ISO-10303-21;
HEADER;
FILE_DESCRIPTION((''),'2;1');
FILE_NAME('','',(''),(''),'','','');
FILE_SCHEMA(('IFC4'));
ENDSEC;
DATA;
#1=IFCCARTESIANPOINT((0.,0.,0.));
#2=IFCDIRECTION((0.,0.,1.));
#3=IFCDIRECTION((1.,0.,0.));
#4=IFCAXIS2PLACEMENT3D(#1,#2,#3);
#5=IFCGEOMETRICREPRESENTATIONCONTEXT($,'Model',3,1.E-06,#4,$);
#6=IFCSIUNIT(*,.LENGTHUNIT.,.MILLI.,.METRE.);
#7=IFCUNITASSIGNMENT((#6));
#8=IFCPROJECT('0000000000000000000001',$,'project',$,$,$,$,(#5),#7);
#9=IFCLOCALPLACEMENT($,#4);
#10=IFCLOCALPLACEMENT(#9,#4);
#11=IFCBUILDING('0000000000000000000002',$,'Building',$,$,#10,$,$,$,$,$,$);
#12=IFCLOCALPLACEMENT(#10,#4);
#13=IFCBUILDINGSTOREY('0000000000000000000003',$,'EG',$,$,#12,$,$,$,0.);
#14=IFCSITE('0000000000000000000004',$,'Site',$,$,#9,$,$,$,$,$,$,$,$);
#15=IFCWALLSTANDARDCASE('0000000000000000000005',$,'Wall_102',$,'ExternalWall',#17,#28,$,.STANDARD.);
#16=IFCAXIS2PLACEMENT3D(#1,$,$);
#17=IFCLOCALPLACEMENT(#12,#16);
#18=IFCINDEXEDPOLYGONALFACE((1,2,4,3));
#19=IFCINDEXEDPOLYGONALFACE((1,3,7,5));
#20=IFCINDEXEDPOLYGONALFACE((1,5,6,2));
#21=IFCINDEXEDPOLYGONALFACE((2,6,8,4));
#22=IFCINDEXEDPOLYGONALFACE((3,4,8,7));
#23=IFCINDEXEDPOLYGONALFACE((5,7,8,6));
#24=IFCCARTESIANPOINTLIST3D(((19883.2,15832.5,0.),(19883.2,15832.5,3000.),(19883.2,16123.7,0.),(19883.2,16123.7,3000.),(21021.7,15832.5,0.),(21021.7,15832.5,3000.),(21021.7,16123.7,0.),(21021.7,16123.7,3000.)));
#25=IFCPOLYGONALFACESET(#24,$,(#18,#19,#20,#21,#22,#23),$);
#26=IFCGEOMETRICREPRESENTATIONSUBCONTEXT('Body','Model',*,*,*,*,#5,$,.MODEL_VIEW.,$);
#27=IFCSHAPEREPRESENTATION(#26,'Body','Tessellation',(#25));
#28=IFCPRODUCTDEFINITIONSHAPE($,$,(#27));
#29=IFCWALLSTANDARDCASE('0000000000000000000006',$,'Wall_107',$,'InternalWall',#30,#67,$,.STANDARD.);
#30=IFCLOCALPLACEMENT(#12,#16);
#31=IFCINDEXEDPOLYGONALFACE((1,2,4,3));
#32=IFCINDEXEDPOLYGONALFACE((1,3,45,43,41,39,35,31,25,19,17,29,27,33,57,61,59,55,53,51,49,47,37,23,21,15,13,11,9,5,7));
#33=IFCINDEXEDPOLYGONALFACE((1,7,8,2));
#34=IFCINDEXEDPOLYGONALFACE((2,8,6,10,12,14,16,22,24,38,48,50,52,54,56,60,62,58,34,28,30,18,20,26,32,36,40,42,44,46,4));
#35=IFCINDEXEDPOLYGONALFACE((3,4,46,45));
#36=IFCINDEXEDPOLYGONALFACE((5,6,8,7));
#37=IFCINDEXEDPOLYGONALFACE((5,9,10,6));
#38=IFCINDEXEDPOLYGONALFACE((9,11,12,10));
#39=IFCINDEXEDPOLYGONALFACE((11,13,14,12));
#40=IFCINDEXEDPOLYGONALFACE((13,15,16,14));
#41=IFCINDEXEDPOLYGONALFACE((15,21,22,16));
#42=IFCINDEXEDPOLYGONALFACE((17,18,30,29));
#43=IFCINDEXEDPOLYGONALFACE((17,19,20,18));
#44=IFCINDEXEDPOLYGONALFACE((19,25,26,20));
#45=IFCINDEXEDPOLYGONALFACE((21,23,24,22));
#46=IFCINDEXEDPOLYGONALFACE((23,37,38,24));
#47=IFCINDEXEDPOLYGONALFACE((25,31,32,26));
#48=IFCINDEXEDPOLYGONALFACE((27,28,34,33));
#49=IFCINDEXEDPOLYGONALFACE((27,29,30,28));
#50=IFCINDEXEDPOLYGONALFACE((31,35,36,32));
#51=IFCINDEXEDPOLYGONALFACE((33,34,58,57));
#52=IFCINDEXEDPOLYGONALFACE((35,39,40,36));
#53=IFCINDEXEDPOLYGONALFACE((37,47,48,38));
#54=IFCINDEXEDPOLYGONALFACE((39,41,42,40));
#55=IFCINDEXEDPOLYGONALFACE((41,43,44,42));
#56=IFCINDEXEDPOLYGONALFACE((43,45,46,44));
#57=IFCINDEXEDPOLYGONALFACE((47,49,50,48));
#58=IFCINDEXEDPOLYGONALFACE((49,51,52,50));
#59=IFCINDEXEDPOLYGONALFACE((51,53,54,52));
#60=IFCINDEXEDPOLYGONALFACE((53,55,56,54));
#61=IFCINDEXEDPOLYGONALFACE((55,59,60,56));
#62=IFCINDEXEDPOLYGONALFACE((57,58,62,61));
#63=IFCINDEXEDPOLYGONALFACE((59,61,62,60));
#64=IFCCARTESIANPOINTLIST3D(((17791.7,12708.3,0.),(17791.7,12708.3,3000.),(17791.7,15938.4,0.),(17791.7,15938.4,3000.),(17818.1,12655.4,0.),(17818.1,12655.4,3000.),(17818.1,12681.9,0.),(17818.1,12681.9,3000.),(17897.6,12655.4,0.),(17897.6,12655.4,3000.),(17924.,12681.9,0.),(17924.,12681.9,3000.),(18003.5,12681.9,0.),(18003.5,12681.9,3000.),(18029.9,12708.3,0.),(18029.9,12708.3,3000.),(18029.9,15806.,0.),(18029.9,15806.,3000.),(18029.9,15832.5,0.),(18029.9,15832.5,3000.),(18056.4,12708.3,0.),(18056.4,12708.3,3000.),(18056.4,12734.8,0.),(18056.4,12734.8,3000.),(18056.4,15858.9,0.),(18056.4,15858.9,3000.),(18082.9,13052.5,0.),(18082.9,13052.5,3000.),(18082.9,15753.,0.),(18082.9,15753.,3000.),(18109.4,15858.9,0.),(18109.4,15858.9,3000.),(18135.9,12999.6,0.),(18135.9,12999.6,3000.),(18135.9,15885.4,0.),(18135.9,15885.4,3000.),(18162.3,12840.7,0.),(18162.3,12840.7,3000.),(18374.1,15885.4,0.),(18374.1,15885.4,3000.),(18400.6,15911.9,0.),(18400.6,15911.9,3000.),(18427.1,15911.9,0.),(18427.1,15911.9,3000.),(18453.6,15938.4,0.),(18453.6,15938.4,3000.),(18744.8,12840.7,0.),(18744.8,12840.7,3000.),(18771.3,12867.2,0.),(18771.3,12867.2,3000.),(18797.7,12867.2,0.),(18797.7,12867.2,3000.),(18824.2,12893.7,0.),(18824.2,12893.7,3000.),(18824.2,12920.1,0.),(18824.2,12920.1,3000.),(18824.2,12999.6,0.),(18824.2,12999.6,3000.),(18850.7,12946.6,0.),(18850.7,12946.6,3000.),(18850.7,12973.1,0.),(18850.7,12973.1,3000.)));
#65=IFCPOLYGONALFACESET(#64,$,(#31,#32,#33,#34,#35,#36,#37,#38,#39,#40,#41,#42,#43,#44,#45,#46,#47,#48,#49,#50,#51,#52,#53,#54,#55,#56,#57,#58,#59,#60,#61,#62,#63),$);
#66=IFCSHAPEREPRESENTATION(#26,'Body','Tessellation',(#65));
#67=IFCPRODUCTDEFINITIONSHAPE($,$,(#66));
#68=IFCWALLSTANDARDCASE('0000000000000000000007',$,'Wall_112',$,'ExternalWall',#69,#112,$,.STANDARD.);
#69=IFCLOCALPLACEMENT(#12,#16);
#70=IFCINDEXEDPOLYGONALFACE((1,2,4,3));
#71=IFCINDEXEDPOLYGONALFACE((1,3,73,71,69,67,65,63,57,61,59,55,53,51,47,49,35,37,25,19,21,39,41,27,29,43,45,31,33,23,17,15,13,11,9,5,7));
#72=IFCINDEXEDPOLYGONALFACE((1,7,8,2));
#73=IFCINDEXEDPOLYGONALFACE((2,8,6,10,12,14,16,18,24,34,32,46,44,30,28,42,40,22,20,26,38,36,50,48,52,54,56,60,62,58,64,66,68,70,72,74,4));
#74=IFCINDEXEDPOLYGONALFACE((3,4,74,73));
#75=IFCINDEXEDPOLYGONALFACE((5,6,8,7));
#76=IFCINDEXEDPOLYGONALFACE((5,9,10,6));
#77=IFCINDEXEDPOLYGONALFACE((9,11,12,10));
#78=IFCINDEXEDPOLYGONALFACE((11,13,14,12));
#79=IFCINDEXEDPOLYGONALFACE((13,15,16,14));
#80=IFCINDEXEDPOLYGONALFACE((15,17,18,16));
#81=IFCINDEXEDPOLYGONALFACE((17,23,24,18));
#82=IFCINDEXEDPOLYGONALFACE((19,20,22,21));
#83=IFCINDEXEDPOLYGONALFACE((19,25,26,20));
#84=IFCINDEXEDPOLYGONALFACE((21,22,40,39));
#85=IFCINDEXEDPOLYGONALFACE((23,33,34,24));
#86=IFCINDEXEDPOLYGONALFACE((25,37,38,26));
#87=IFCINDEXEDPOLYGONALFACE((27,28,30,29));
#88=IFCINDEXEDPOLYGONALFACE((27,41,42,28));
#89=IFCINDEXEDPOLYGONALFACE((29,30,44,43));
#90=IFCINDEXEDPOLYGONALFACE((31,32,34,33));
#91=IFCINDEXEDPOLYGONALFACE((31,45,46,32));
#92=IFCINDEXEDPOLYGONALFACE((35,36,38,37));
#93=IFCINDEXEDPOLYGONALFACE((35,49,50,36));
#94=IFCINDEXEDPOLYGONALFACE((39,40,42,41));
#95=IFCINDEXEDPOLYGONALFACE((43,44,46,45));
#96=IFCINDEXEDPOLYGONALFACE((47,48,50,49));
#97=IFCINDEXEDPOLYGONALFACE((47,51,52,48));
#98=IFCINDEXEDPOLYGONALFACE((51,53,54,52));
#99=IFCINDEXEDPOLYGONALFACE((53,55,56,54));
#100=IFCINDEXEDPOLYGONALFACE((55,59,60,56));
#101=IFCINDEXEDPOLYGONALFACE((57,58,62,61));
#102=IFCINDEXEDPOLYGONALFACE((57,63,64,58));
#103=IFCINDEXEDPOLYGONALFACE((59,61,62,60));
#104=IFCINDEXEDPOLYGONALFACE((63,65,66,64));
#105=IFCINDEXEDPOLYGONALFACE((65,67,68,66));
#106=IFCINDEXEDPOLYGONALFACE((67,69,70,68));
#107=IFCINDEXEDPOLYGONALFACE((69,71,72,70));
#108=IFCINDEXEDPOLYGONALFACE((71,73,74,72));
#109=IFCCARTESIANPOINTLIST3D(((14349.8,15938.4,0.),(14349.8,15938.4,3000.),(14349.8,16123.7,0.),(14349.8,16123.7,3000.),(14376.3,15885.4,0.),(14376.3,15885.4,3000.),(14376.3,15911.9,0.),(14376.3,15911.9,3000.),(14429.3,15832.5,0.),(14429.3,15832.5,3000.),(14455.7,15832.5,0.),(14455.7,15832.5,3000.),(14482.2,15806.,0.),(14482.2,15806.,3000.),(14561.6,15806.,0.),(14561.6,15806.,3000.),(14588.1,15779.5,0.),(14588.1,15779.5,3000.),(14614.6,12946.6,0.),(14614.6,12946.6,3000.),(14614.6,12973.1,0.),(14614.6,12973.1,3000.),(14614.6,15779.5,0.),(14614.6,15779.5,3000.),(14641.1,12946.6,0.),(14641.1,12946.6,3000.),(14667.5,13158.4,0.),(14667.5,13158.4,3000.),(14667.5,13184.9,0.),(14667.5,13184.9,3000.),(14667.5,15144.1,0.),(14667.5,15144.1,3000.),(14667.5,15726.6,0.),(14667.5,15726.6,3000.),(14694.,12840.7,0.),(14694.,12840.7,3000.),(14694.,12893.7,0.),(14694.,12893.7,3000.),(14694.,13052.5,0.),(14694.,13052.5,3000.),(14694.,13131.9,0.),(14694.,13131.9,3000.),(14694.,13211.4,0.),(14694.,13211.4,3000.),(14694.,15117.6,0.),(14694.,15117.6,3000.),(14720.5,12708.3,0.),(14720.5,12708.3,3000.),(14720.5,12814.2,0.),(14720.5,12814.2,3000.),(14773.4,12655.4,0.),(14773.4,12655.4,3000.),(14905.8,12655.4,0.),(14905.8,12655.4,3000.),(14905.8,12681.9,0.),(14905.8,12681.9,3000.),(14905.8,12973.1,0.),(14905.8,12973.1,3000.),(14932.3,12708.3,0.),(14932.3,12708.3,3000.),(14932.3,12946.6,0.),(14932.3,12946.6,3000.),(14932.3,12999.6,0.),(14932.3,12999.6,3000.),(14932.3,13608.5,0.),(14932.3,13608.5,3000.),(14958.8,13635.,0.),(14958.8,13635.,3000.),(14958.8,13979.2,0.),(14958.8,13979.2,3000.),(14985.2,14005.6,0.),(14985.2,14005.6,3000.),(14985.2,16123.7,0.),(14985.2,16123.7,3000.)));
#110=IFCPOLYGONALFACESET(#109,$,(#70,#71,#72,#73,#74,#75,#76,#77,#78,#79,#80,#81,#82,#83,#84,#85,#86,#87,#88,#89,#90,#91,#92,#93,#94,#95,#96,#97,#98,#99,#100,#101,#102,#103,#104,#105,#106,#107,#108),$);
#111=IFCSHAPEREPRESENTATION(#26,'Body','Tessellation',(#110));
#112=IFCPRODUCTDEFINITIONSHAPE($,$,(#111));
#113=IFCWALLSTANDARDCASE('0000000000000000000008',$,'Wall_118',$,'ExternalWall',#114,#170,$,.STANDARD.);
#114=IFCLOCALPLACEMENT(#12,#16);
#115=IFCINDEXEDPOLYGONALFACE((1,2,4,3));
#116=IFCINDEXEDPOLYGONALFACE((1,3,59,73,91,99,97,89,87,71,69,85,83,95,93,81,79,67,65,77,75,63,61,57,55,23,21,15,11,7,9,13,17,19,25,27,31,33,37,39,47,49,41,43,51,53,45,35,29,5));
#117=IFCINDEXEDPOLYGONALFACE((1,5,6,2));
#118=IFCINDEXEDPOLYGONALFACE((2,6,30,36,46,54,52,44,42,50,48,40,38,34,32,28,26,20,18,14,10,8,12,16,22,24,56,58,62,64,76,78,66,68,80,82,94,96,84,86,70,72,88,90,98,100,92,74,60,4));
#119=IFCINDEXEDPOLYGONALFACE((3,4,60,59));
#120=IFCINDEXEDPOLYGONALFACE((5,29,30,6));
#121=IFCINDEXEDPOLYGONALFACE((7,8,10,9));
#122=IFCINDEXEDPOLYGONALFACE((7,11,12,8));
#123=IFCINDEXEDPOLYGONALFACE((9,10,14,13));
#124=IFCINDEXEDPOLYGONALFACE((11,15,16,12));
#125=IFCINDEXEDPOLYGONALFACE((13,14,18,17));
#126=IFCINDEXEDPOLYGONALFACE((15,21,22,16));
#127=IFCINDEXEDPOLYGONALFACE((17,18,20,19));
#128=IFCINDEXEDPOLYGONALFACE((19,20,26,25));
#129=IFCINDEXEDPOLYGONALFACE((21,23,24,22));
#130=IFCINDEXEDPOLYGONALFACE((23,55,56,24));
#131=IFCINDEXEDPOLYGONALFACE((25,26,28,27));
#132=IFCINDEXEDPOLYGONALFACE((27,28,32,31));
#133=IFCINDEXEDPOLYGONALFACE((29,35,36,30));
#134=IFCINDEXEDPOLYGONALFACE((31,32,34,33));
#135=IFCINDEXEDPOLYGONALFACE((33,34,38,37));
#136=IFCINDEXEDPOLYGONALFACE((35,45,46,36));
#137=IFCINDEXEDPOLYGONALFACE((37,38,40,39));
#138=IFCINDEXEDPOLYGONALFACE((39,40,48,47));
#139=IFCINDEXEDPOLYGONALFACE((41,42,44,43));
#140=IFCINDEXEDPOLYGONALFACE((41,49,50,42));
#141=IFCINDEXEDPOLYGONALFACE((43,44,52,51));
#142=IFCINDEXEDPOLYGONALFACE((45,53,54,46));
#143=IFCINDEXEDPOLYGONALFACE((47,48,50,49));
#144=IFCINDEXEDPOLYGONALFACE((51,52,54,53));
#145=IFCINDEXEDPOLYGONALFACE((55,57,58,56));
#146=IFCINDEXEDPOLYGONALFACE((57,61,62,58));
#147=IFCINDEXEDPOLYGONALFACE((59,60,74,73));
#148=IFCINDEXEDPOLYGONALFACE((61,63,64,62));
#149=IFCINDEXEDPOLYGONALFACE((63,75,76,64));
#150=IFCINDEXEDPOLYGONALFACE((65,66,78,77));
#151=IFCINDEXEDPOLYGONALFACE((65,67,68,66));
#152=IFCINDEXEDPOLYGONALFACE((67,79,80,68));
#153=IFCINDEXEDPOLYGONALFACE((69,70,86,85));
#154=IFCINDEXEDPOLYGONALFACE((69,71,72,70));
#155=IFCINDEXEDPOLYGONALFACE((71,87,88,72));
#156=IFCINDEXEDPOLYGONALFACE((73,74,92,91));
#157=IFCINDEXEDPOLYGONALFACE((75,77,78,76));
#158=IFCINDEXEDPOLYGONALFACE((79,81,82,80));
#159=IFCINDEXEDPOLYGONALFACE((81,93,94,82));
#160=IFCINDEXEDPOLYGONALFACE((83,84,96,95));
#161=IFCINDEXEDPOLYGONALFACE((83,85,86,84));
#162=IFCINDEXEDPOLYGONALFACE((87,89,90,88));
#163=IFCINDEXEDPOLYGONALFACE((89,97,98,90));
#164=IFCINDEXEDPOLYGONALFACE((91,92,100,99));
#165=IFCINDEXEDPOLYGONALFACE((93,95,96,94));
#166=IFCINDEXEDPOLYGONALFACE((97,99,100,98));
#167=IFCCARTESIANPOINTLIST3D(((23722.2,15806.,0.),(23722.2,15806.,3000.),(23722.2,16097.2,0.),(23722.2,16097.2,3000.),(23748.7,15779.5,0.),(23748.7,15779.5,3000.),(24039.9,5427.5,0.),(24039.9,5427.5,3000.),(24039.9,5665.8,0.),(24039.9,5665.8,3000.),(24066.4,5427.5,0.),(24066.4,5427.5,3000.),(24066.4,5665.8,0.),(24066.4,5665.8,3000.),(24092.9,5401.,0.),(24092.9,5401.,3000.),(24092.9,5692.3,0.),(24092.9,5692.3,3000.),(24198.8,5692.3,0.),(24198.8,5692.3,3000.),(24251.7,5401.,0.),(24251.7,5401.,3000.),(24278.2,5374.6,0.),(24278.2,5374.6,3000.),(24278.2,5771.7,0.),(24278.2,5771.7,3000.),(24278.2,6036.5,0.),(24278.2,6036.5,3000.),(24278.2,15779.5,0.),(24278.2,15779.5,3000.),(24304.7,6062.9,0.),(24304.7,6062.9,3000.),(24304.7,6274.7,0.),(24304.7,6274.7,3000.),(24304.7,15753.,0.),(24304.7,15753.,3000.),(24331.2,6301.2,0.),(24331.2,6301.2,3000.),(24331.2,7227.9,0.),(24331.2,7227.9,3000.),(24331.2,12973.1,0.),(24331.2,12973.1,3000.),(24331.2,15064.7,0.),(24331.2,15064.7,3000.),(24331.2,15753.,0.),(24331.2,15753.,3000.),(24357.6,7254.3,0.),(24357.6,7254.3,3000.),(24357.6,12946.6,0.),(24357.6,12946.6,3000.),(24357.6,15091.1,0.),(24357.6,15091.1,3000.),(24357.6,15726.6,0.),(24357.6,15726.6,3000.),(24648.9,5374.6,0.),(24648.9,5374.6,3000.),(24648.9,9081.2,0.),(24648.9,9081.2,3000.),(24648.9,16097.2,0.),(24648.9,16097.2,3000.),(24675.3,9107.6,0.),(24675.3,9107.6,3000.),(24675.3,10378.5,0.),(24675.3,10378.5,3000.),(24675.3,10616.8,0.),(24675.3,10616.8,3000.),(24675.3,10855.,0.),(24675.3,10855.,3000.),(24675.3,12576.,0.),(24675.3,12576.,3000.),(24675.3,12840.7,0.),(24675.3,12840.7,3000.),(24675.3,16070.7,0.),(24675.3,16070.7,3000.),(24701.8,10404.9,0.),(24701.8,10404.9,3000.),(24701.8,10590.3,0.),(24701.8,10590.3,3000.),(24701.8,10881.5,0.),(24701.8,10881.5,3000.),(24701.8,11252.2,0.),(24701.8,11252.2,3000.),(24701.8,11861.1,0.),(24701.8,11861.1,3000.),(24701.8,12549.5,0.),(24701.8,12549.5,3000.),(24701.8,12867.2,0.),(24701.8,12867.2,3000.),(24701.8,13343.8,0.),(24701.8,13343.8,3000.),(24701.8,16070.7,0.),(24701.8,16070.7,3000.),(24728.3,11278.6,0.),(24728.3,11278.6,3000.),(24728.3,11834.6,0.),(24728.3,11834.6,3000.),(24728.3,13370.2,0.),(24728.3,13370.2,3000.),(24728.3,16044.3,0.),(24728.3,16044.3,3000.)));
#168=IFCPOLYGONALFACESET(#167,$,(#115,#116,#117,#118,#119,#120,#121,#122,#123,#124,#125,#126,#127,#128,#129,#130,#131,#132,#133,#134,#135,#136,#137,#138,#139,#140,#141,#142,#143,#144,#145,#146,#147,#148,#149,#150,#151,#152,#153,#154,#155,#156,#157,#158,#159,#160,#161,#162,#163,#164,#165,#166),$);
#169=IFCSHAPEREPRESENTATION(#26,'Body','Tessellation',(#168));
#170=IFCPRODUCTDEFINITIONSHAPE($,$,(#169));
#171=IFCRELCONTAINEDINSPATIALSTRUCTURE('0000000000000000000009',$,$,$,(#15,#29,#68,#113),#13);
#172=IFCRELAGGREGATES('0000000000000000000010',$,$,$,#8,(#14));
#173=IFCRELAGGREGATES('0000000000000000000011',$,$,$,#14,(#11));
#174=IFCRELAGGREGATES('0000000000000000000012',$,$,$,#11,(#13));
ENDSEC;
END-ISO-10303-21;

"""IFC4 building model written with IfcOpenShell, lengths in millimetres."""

from ifc_helpers import new_model, si_unit, frame, origin_with_axes, place, context, subcontext, project, spatial, polyline, outline, extrude, element, save


model = new_model("IFC4")

# Units and contexts
model_context = context("Model", 3, precision=1e-06, world=origin_with_axes())
body_context = subcontext(model_context, "Body", "Model", "MODEL_VIEW")
ifc_project = project(units=[si_unit("LENGTHUNIT", "METRE", prefix="MILLI")], contexts=[model_context])

# Site, building, storey
site_placement = place(None, origin_with_axes())
site = spatial("IfcSite", under=ifc_project, at=site_placement, Name="Site")
building_placement = place(site_placement, origin_with_axes())
building = spatial("IfcBuilding", under=site, at=building_placement, Name="Building")
storey_placement = place(building_placement, origin_with_axes())
storey = spatial("IfcBuildingStorey", under=building, at=storey_placement, Name="EG", Elevation=0.0)

# Walls
for number, where, z_axis, x_axis, name in (
    (1, (0.0, 0.0, 0.0), (0.0, 0.0, 1.0), (1.0, 0.0, 0.0), "Wall_102"),
):
    element("IfcWallStandardCase", number, at=place(storey_placement, frame(where, z_axis=z_axis, x_axis=x_axis)), inside=storey, Name=name, ObjectType="ExternalWall", PredefinedType="STANDARD", context=body_context, shape_type="SweptSolid", body=[
        extrude(outline(polyline([(19883.2, 15832.5, 0.0), (19883.2, 16123.7, 0.0), (21021.7, 16123.7, 0.0), (21021.7, 15832.5, 0.0), (19883.2, 15832.5, 0.0)])), origin_with_axes(), (0.0, 0.0, 1.0), 3000.0),
    ])
for number, where, z_axis, x_axis, name in (
    (2, (0.0, 0.0, 0.0), (0.0, 0.0, 1.0), (1.0, 0.0, 0.0), "Wall_107"),
):
    element("IfcWallStandardCase", number, at=place(storey_placement, frame(where, z_axis=z_axis, x_axis=x_axis)), inside=storey, Name=name, ObjectType="InternalWall", PredefinedType="STANDARD", context=body_context, shape_type="SweptSolid", body=[
        extrude(outline(polyline([(17818.1, 12655.4, 0.0), (17818.1, 12681.9, 0.0), (17791.7, 12708.3, 0.0), (17791.7, 15938.4, 0.0), (18453.6, 15938.4, 0.0), (18427.1, 15911.9, 0.0), (18400.6, 15911.9, 0.0), (18374.1, 15885.4, 0.0), (18135.9, 15885.4, 0.0), (18109.4, 15858.9, 0.0), (18056.4, 15858.9, 0.0), (18029.9, 15832.5, 0.0), (18029.9, 15806.0, 0.0), (18082.9, 15753.0, 0.0), (18082.9, 13052.5, 0.0), (18135.9, 12999.6, 0.0), (18824.2, 12999.6, 0.0), (18850.7, 12973.1, 0.0), (18850.7, 12946.6, 0.0), (18824.2, 12920.1, 0.0), (18824.2, 12893.7, 0.0), (18797.7, 12867.2, 0.0), (18771.3, 12867.2, 0.0), (18744.8, 12840.7, 0.0), (18162.3, 12840.7, 0.0), (18056.4, 12734.8, 0.0), (18056.4, 12708.3, 0.0), (18029.9, 12708.3, 0.0), (18003.5, 12681.9, 0.0), (17924.0, 12681.9, 0.0), (17897.6, 12655.4, 0.0), (17818.1, 12655.4, 0.0)])), origin_with_axes(), (0.0, 0.0, 1.0), 3000.0),
    ])
for number, where, z_axis, x_axis, name in (
    (3, (0.0, 0.0, 0.0), (0.0, 0.0, 1.0), (1.0, 0.0, 0.0), "Wall_112"),
):
    element("IfcWallStandardCase", number, at=place(storey_placement, frame(where, z_axis=z_axis, x_axis=x_axis)), inside=storey, Name=name, ObjectType="ExternalWall", PredefinedType="STANDARD", context=body_context, shape_type="SweptSolid", body=[
        extrude(outline(polyline([(14773.4, 12655.4, 0.0), (14720.5, 12708.3, 0.0), (14720.5, 12814.2, 0.0), (14694.0, 12840.7, 0.0), (14694.0, 12893.7, 0.0), (14641.1, 12946.6, 0.0), (14614.6, 12946.6, 0.0), (14614.6, 12973.1, 0.0), (14694.0, 13052.5, 0.0), (14694.0, 13131.9, 0.0), (14667.5, 13158.4, 0.0), (14667.5, 13184.9, 0.0), (14694.0, 13211.4, 0.0), (14694.0, 15117.6, 0.0), (14667.5, 15144.1, 0.0), (14667.5, 15726.6, 0.0), (14614.6, 15779.5, 0.0), (14588.1, 15779.5, 0.0), (14561.6, 15806.0, 0.0), (14482.2, 15806.0, 0.0), (14455.7, 15832.5, 0.0), (14429.3, 15832.5, 0.0), (14376.3, 15885.4, 0.0), (14376.3, 15911.9, 0.0), (14349.8, 15938.4, 0.0), (14349.8, 16123.7, 0.0), (14985.2, 16123.7, 0.0), (14985.2, 14005.6, 0.0), (14958.8, 13979.2, 0.0), (14958.8, 13635.0, 0.0), (14932.3, 13608.5, 0.0), (14932.3, 12999.6, 0.0), (14905.8, 12973.1, 0.0), (14932.3, 12946.6, 0.0), (14932.3, 12708.3, 0.0), (14905.8, 12681.9, 0.0), (14905.8, 12655.4, 0.0), (14773.4, 12655.4, 0.0)])), origin_with_axes(), (0.0, 0.0, 1.0), 3000.0),
    ])
wall_1_placement = place(storey_placement, origin_with_axes())
element("IfcWallStandardCase", 4, at=wall_1_placement, inside=storey, Name="Wall_118", ObjectType="ExternalWall", PredefinedType="STANDARD", context=body_context, shape_type="SweptSolid", body=[
    extrude(outline(polyline([(24278.2, 5374.6, 0.0), (24251.7, 5401.0, 0.0), (24092.9, 5401.0, 0.0), (24066.4, 5427.5, 0.0), (24039.9, 5427.5, 0.0), (24039.9, 5665.8, 0.0), (24066.4, 5665.8, 0.0), (24092.9, 5692.3, 0.0), (24198.8, 5692.3, 0.0), (24278.2, 5771.7, 0.0), (24278.2, 6036.5, 0.0), (24304.7, 6062.9, 0.0), (24304.7, 6274.7, 0.0), (24331.2, 6301.2, 0.0), (24331.2, 7227.9, 0.0), (24357.6, 7254.3, 0.0), (24357.6, 12946.6, 0.0), (24331.2, 12973.1, 0.0), (24331.2, 15064.7, 0.0), (24357.6, 15091.1, 0.0), (24357.6, 15726.6, 0.0), (24331.2, 15753.0, 0.0), (24304.7, 15753.0, 0.0), (24278.2, 15779.5, 0.0), (23748.7, 15779.5, 0.0), (23722.2, 15806.0, 0.0), (23722.2, 16097.2, 0.0), (24648.9, 16097.2, 0.0), (24675.3, 16070.7, 0.0), (24701.8, 16070.7, 0.0), (24728.3, 16044.3, 0.0), (24728.3, 13370.2, 0.0), (24701.8, 13343.8, 0.0), (24701.8, 12867.2, 0.0), (24675.3, 12840.7, 0.0), (24675.3, 12576.0, 0.0), (24701.8, 12549.5, 0.0), (24701.8, 11861.1, 0.0), (24728.3, 11834.6, 0.0), (24728.3, 11278.6, 0.0), (24701.8, 11252.2, 0.0), (24701.8, 10881.5, 0.0), (24675.3, 10855.0, 0.0), (24675.3, 10616.8, 0.0), (24701.8, 10590.3, 0.0), (24701.8, 10404.9, 0.0), (24675.3, 10378.5, 0.0), (24675.3, 9107.6, 0.0), (24648.9, 9081.2, 0.0), (24648.9, 5374.6, 0.0), (24278.2, 5374.6, 0.0)])), origin_with_axes(), (0.0, 0.0, 1.0), 3000.0),
])

save(model, "model.ifc")
